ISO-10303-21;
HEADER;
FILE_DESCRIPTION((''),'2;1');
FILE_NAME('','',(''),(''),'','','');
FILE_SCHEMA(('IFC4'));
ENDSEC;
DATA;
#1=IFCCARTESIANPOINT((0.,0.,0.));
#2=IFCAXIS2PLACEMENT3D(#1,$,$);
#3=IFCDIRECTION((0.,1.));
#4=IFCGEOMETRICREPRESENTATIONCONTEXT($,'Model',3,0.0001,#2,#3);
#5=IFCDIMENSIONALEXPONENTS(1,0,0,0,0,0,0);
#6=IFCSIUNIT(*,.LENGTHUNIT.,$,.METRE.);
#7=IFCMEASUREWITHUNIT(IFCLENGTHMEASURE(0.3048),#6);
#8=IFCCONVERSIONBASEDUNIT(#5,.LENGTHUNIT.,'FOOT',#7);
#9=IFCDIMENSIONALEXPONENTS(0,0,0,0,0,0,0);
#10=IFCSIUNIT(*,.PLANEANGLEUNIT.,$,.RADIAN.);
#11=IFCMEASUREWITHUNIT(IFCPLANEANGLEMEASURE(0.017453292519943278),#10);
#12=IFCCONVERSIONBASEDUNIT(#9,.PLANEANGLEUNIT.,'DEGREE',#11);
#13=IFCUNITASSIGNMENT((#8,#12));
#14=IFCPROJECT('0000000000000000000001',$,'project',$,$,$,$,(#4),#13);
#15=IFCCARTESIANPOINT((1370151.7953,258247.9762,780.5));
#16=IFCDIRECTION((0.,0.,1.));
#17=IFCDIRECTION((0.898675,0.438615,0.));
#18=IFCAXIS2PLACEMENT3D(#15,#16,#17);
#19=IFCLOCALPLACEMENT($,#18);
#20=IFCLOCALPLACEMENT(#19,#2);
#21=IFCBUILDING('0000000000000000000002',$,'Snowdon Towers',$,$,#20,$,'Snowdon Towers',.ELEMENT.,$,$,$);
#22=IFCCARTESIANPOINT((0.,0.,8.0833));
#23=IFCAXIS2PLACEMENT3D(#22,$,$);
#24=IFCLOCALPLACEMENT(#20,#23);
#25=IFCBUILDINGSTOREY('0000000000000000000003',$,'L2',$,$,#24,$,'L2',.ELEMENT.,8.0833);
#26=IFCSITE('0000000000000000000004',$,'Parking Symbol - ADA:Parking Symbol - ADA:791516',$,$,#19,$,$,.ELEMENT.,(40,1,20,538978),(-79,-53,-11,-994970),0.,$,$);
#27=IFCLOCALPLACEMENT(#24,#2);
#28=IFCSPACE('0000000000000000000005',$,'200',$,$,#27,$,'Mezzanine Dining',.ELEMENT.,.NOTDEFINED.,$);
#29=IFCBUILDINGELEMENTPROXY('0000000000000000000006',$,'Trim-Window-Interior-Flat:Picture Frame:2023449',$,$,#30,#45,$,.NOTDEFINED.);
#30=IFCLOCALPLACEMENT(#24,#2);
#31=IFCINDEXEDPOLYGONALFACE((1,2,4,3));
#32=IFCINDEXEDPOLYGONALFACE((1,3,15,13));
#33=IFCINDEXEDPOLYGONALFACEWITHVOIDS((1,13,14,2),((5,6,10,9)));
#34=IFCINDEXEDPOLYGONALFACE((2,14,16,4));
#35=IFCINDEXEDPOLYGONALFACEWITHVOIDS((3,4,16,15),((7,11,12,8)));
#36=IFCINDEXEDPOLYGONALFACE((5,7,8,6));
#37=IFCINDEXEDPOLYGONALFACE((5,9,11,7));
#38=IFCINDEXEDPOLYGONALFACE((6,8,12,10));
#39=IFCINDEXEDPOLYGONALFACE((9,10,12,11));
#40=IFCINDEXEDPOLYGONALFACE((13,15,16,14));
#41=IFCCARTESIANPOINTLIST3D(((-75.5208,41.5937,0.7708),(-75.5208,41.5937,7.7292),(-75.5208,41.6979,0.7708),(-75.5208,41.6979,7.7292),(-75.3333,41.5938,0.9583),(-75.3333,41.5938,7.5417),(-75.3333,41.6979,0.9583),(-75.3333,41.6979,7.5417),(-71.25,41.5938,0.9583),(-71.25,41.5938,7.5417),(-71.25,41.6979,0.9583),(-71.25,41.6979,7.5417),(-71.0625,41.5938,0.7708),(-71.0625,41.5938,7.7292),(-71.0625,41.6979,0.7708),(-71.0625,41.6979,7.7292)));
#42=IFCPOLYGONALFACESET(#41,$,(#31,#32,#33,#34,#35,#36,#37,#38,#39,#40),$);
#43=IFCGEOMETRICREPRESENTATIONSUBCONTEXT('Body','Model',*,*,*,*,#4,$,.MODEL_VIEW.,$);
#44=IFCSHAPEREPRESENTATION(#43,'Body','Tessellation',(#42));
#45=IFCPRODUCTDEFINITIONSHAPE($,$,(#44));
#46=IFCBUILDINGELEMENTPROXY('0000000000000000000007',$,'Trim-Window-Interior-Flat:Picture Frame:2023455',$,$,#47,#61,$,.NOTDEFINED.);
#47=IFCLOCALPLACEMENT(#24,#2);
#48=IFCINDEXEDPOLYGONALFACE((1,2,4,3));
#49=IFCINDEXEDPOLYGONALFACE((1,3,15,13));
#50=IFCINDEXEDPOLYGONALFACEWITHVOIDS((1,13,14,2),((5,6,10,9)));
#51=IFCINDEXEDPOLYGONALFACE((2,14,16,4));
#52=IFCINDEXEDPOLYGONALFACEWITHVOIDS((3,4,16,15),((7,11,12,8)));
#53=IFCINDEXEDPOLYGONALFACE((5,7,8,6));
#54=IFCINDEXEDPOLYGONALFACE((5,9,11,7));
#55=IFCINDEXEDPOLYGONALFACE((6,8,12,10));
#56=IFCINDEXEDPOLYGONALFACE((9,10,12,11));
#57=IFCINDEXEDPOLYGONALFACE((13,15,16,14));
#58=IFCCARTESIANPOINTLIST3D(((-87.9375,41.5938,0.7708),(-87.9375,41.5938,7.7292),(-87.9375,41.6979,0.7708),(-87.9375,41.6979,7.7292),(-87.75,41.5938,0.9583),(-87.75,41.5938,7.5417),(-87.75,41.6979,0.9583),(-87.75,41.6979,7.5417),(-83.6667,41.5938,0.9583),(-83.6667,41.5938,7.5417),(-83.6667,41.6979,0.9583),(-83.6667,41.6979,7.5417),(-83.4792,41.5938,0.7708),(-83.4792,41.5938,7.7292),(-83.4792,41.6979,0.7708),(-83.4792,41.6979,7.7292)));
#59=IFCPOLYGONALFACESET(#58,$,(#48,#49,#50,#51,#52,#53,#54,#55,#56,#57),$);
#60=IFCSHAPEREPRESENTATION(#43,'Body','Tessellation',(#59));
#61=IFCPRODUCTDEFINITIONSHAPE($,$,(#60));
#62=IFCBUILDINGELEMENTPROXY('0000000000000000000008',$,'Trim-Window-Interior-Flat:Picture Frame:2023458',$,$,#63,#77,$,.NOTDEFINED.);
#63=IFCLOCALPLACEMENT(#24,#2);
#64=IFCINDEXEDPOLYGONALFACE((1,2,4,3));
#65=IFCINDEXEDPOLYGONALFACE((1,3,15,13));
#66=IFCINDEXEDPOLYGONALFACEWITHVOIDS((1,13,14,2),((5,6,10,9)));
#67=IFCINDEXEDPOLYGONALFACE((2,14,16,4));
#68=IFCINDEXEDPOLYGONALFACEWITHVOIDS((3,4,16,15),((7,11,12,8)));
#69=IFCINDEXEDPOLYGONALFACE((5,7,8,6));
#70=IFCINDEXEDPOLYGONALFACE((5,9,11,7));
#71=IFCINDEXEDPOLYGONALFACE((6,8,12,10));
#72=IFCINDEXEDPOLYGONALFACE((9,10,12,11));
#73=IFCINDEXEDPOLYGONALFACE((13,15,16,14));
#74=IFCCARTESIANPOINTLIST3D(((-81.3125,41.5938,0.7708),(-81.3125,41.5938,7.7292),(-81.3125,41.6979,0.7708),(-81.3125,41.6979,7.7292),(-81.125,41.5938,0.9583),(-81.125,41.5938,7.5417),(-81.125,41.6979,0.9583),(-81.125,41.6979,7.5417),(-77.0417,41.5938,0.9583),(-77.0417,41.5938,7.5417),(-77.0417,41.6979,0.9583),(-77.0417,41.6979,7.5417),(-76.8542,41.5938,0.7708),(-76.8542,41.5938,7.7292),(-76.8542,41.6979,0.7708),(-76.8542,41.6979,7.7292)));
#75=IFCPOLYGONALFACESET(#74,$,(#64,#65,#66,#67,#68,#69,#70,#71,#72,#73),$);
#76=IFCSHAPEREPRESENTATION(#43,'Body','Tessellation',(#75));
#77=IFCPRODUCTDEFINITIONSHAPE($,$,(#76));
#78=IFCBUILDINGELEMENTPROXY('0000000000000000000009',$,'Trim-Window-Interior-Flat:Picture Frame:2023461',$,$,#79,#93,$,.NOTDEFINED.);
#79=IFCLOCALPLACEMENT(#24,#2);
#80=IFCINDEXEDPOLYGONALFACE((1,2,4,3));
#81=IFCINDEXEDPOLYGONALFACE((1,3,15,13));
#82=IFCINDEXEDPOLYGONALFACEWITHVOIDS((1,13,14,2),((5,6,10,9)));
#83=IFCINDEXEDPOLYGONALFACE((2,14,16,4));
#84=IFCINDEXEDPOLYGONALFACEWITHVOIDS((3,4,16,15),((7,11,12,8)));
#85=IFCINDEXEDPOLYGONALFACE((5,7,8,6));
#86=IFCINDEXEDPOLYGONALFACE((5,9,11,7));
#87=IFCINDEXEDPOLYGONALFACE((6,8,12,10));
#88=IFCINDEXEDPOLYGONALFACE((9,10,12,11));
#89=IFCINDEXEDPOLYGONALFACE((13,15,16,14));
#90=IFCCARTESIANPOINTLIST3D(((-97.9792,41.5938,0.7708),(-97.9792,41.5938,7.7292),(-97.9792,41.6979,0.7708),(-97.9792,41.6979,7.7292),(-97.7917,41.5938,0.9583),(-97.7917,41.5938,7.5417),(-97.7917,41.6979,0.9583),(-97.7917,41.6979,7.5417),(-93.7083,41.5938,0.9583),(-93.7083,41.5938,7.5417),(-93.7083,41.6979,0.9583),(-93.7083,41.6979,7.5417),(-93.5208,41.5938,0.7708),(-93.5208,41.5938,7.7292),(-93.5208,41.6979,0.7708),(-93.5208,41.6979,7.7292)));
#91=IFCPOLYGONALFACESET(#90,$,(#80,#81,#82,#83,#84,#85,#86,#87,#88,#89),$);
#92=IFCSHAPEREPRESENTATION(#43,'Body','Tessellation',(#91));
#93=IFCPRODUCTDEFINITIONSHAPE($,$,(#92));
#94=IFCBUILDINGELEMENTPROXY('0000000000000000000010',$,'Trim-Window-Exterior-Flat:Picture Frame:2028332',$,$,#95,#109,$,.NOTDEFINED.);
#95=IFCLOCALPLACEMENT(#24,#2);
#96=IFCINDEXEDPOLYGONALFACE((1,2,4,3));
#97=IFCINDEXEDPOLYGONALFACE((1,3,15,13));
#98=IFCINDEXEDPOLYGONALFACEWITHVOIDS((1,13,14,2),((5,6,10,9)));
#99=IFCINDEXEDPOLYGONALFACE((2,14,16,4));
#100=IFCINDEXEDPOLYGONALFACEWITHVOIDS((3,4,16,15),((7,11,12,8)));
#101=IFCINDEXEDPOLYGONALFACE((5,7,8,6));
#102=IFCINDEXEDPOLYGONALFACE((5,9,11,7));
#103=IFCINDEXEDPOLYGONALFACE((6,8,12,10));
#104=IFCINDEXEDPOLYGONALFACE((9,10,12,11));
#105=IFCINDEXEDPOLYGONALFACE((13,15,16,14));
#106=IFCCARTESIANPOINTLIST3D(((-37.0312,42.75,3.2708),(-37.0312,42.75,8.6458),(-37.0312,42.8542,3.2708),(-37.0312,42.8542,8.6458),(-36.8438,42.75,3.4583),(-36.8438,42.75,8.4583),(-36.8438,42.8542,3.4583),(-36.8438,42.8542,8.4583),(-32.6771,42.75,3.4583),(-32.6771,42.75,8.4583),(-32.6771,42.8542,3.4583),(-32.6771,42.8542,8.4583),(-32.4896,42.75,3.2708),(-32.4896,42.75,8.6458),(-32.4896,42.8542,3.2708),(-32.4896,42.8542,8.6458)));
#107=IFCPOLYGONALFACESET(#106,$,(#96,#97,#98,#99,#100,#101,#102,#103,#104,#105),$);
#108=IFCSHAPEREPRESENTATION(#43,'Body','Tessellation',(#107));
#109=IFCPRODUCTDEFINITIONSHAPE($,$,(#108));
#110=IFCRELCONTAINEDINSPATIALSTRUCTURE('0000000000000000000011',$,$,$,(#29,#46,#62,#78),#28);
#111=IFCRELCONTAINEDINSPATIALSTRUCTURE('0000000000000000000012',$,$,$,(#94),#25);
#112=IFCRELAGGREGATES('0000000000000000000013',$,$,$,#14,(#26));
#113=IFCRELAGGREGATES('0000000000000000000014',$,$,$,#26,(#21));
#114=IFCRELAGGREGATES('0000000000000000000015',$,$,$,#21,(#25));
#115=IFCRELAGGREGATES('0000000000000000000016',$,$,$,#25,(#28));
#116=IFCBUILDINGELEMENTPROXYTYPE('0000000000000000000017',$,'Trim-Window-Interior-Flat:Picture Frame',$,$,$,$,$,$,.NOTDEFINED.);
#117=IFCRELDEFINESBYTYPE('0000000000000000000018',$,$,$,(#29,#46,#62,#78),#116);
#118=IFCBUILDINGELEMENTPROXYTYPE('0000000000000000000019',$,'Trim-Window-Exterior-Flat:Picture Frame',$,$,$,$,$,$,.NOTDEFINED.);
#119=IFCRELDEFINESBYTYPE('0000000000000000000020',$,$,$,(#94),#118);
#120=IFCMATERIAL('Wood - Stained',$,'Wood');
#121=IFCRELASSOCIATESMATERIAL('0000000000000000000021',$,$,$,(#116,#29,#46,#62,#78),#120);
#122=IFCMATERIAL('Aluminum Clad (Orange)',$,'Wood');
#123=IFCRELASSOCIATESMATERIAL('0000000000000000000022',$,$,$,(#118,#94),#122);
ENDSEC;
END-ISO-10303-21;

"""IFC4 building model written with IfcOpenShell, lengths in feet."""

from ifc_helpers import new_model, entity, si_unit, converted_unit, direction, frame, origin, place, context, subcontext, project, spatial, indexed_curve, outline, extrude, source, transform, mapped, material, type_object, type_shapes, element, save


model = new_model("IFC4")

# Units and contexts
model_context = context("Model", 3, precision=0.0001, world=origin(), true_north=direction((0.0, 1.0)))
body_context = subcontext(model_context, "Body", "Model", "MODEL_VIEW")
ifc_project = project(units=[converted_unit("LENGTHUNIT", "FOOT", entity("IfcLengthMeasure", 0.3048), si_unit("LENGTHUNIT", "METRE"), dimensions=[1, 0, 0, 0, 0, 0, 0]), converted_unit("PLANEANGLEUNIT", "DEGREE", entity("IfcPlaneAngleMeasure", 0.017453292519943278), si_unit("PLANEANGLEUNIT", "RADIAN"), dimensions=[0, 0, 0, 0, 0, 0, 0])], contexts=[model_context])

# Site, building, storey
site_placement = place(None, frame((1370151.7953, 258247.9762, 780.5), z_axis=(0.0, 0.0, 1.0), x_axis=(0.898675, 0.438615, 0.0)))
site = spatial("IfcSite", under=ifc_project, at=site_placement, Name="Parking Symbol - ADA:Parking Symbol - ADA:791516", CompositionType="ELEMENT", RefLatitude=(40, 1, 20, 538978), RefLongitude=(-79, -53, -11, -994970), RefElevation=0.0)
building_placement = place(site_placement, origin())
building = spatial("IfcBuilding", under=site, at=building_placement, Name="Snowdon Towers", LongName="Snowdon Towers", CompositionType="ELEMENT")
storey_placement = place(building_placement, frame((0.0, 0.0, 8.0833)))
storey = spatial("IfcBuildingStorey", under=building, at=storey_placement, Name="L2", LongName="L2", CompositionType="ELEMENT", Elevation=8.0833)

# Shared definitions
space_1_placement = place(storey_placement, origin())
space_1 = spatial("IfcSpace", under=storey, at=space_1_placement, Name="200", LongName="Mezzanine Dining", CompositionType="ELEMENT", PredefinedType="NOTDEFINED")

# Shared definitions
ifc_material_1 = material(Name="Wood - Stained", Category="Wood")

# Building element proxies
building_element_proxy_type_1 = type_object("IfcBuildingElementProxyType", Name="Trim-Window-Interior-Flat:Picture Frame", PredefinedType="NOTDEFINED", material=ifc_material_1)
shared_shape_1 = source(origin(), body_context, "Body", "SweptSolid", [
    extrude(outline(indexed_curve([(-2.2292, -3.4792), (2.2292, -3.4792), (2.2292, 3.4792), (-2.2292, 3.4792), (-2.2292, -3.4792)], self_intersect=False), holes=[indexed_curve([(-2.0417, -3.2917), (-2.0417, 3.2917), (2.0417, 3.2917), (2.0417, -3.2917), (-2.0417, -3.2917)], self_intersect=False)]), frame((0.0, -3.3333, 0.0), z_axis=(0.0, 0.0, 1.0), x_axis=(-1.0, 0.0, 0.0)), (0.0, 0.0, 1.0), 0.1042),
])
type_shapes(building_element_proxy_type_1, [shared_shape_1])
for number, where, z_axis, x_axis, name in (
    (1, (-73.2917, 41.6979, 7.5833), (0.0, -1.0, 0.0), (1.0, 0.0, 0.0), "Trim-Window-Interior-Flat:Picture Frame:2023449"),
    (2, (-85.7083, 41.6979, 7.5833), (0.0, -1.0, 0.0), (1.0, 0.0, 0.0), "Trim-Window-Interior-Flat:Picture Frame:2023455"),
    (3, (-79.0833, 41.6979, 7.5833), (0.0, -1.0, 0.0), (1.0, 0.0, 0.0), "Trim-Window-Interior-Flat:Picture Frame:2023458"),
    (4, (-95.75, 41.6979, 7.5833), (0.0, -1.0, 0.0), (1.0, 0.0, 0.0), "Trim-Window-Interior-Flat:Picture Frame:2023461"),
):
    element("IfcBuildingElementProxy", number, at=place(space_1_placement, frame(where, z_axis=z_axis, x_axis=x_axis)), inside=space_1, type_object=building_element_proxy_type_1, material=ifc_material_1, Name=name, PredefinedType="NOTDEFINED", context=body_context, shape_type="MappedRepresentation", body=[
        mapped(shared_shape_1, transform((0.0, 0.0, 0.0), scale=1.0)),
    ])
ifc_material_2 = material(Name="Aluminum Clad (Orange)", Category="Wood")
building_element_proxy_type_2 = type_object("IfcBuildingElementProxyType", Name="Trim-Window-Exterior-Flat:Picture Frame", PredefinedType="NOTDEFINED", material=ifc_material_2)
shared_shape_2 = source(origin(), body_context, "Body", "SweptSolid", [
    extrude(outline(indexed_curve([(-2.2708, -2.6875), (2.2708, -2.6875), (2.2708, 2.6875), (-2.2708, 2.6875), (-2.2708, -2.6875)], self_intersect=False), holes=[indexed_curve([(-2.0833, -2.5), (-2.0833, 2.5), (2.0833, 2.5), (2.0833, -2.5), (-2.0833, -2.5)], self_intersect=False)]), frame((0.0, -2.5, 0.0), z_axis=(0.0, 0.0, 1.0), x_axis=(-1.0, 0.0, 0.0)), (0.0, 0.0, 1.0), 0.1042),
])
type_shapes(building_element_proxy_type_2, [shared_shape_2])
proxy_1_placement = place(storey_placement, frame((-34.7604, 42.75, 8.4583), z_axis=(0.0, 1.0, 0.0), x_axis=(-1.0, 0.0, 0.0)))
element("IfcBuildingElementProxy", 5, at=proxy_1_placement, inside=storey, type_object=building_element_proxy_type_2, material=ifc_material_2, Name="Trim-Window-Exterior-Flat:Picture Frame:2028332", PredefinedType="NOTDEFINED", context=body_context, shape_type="MappedRepresentation", body=[
    mapped(shared_shape_2, transform((0.0, 0.0, 0.0), scale=1.0)),
])

save(model, "model.ifc")
